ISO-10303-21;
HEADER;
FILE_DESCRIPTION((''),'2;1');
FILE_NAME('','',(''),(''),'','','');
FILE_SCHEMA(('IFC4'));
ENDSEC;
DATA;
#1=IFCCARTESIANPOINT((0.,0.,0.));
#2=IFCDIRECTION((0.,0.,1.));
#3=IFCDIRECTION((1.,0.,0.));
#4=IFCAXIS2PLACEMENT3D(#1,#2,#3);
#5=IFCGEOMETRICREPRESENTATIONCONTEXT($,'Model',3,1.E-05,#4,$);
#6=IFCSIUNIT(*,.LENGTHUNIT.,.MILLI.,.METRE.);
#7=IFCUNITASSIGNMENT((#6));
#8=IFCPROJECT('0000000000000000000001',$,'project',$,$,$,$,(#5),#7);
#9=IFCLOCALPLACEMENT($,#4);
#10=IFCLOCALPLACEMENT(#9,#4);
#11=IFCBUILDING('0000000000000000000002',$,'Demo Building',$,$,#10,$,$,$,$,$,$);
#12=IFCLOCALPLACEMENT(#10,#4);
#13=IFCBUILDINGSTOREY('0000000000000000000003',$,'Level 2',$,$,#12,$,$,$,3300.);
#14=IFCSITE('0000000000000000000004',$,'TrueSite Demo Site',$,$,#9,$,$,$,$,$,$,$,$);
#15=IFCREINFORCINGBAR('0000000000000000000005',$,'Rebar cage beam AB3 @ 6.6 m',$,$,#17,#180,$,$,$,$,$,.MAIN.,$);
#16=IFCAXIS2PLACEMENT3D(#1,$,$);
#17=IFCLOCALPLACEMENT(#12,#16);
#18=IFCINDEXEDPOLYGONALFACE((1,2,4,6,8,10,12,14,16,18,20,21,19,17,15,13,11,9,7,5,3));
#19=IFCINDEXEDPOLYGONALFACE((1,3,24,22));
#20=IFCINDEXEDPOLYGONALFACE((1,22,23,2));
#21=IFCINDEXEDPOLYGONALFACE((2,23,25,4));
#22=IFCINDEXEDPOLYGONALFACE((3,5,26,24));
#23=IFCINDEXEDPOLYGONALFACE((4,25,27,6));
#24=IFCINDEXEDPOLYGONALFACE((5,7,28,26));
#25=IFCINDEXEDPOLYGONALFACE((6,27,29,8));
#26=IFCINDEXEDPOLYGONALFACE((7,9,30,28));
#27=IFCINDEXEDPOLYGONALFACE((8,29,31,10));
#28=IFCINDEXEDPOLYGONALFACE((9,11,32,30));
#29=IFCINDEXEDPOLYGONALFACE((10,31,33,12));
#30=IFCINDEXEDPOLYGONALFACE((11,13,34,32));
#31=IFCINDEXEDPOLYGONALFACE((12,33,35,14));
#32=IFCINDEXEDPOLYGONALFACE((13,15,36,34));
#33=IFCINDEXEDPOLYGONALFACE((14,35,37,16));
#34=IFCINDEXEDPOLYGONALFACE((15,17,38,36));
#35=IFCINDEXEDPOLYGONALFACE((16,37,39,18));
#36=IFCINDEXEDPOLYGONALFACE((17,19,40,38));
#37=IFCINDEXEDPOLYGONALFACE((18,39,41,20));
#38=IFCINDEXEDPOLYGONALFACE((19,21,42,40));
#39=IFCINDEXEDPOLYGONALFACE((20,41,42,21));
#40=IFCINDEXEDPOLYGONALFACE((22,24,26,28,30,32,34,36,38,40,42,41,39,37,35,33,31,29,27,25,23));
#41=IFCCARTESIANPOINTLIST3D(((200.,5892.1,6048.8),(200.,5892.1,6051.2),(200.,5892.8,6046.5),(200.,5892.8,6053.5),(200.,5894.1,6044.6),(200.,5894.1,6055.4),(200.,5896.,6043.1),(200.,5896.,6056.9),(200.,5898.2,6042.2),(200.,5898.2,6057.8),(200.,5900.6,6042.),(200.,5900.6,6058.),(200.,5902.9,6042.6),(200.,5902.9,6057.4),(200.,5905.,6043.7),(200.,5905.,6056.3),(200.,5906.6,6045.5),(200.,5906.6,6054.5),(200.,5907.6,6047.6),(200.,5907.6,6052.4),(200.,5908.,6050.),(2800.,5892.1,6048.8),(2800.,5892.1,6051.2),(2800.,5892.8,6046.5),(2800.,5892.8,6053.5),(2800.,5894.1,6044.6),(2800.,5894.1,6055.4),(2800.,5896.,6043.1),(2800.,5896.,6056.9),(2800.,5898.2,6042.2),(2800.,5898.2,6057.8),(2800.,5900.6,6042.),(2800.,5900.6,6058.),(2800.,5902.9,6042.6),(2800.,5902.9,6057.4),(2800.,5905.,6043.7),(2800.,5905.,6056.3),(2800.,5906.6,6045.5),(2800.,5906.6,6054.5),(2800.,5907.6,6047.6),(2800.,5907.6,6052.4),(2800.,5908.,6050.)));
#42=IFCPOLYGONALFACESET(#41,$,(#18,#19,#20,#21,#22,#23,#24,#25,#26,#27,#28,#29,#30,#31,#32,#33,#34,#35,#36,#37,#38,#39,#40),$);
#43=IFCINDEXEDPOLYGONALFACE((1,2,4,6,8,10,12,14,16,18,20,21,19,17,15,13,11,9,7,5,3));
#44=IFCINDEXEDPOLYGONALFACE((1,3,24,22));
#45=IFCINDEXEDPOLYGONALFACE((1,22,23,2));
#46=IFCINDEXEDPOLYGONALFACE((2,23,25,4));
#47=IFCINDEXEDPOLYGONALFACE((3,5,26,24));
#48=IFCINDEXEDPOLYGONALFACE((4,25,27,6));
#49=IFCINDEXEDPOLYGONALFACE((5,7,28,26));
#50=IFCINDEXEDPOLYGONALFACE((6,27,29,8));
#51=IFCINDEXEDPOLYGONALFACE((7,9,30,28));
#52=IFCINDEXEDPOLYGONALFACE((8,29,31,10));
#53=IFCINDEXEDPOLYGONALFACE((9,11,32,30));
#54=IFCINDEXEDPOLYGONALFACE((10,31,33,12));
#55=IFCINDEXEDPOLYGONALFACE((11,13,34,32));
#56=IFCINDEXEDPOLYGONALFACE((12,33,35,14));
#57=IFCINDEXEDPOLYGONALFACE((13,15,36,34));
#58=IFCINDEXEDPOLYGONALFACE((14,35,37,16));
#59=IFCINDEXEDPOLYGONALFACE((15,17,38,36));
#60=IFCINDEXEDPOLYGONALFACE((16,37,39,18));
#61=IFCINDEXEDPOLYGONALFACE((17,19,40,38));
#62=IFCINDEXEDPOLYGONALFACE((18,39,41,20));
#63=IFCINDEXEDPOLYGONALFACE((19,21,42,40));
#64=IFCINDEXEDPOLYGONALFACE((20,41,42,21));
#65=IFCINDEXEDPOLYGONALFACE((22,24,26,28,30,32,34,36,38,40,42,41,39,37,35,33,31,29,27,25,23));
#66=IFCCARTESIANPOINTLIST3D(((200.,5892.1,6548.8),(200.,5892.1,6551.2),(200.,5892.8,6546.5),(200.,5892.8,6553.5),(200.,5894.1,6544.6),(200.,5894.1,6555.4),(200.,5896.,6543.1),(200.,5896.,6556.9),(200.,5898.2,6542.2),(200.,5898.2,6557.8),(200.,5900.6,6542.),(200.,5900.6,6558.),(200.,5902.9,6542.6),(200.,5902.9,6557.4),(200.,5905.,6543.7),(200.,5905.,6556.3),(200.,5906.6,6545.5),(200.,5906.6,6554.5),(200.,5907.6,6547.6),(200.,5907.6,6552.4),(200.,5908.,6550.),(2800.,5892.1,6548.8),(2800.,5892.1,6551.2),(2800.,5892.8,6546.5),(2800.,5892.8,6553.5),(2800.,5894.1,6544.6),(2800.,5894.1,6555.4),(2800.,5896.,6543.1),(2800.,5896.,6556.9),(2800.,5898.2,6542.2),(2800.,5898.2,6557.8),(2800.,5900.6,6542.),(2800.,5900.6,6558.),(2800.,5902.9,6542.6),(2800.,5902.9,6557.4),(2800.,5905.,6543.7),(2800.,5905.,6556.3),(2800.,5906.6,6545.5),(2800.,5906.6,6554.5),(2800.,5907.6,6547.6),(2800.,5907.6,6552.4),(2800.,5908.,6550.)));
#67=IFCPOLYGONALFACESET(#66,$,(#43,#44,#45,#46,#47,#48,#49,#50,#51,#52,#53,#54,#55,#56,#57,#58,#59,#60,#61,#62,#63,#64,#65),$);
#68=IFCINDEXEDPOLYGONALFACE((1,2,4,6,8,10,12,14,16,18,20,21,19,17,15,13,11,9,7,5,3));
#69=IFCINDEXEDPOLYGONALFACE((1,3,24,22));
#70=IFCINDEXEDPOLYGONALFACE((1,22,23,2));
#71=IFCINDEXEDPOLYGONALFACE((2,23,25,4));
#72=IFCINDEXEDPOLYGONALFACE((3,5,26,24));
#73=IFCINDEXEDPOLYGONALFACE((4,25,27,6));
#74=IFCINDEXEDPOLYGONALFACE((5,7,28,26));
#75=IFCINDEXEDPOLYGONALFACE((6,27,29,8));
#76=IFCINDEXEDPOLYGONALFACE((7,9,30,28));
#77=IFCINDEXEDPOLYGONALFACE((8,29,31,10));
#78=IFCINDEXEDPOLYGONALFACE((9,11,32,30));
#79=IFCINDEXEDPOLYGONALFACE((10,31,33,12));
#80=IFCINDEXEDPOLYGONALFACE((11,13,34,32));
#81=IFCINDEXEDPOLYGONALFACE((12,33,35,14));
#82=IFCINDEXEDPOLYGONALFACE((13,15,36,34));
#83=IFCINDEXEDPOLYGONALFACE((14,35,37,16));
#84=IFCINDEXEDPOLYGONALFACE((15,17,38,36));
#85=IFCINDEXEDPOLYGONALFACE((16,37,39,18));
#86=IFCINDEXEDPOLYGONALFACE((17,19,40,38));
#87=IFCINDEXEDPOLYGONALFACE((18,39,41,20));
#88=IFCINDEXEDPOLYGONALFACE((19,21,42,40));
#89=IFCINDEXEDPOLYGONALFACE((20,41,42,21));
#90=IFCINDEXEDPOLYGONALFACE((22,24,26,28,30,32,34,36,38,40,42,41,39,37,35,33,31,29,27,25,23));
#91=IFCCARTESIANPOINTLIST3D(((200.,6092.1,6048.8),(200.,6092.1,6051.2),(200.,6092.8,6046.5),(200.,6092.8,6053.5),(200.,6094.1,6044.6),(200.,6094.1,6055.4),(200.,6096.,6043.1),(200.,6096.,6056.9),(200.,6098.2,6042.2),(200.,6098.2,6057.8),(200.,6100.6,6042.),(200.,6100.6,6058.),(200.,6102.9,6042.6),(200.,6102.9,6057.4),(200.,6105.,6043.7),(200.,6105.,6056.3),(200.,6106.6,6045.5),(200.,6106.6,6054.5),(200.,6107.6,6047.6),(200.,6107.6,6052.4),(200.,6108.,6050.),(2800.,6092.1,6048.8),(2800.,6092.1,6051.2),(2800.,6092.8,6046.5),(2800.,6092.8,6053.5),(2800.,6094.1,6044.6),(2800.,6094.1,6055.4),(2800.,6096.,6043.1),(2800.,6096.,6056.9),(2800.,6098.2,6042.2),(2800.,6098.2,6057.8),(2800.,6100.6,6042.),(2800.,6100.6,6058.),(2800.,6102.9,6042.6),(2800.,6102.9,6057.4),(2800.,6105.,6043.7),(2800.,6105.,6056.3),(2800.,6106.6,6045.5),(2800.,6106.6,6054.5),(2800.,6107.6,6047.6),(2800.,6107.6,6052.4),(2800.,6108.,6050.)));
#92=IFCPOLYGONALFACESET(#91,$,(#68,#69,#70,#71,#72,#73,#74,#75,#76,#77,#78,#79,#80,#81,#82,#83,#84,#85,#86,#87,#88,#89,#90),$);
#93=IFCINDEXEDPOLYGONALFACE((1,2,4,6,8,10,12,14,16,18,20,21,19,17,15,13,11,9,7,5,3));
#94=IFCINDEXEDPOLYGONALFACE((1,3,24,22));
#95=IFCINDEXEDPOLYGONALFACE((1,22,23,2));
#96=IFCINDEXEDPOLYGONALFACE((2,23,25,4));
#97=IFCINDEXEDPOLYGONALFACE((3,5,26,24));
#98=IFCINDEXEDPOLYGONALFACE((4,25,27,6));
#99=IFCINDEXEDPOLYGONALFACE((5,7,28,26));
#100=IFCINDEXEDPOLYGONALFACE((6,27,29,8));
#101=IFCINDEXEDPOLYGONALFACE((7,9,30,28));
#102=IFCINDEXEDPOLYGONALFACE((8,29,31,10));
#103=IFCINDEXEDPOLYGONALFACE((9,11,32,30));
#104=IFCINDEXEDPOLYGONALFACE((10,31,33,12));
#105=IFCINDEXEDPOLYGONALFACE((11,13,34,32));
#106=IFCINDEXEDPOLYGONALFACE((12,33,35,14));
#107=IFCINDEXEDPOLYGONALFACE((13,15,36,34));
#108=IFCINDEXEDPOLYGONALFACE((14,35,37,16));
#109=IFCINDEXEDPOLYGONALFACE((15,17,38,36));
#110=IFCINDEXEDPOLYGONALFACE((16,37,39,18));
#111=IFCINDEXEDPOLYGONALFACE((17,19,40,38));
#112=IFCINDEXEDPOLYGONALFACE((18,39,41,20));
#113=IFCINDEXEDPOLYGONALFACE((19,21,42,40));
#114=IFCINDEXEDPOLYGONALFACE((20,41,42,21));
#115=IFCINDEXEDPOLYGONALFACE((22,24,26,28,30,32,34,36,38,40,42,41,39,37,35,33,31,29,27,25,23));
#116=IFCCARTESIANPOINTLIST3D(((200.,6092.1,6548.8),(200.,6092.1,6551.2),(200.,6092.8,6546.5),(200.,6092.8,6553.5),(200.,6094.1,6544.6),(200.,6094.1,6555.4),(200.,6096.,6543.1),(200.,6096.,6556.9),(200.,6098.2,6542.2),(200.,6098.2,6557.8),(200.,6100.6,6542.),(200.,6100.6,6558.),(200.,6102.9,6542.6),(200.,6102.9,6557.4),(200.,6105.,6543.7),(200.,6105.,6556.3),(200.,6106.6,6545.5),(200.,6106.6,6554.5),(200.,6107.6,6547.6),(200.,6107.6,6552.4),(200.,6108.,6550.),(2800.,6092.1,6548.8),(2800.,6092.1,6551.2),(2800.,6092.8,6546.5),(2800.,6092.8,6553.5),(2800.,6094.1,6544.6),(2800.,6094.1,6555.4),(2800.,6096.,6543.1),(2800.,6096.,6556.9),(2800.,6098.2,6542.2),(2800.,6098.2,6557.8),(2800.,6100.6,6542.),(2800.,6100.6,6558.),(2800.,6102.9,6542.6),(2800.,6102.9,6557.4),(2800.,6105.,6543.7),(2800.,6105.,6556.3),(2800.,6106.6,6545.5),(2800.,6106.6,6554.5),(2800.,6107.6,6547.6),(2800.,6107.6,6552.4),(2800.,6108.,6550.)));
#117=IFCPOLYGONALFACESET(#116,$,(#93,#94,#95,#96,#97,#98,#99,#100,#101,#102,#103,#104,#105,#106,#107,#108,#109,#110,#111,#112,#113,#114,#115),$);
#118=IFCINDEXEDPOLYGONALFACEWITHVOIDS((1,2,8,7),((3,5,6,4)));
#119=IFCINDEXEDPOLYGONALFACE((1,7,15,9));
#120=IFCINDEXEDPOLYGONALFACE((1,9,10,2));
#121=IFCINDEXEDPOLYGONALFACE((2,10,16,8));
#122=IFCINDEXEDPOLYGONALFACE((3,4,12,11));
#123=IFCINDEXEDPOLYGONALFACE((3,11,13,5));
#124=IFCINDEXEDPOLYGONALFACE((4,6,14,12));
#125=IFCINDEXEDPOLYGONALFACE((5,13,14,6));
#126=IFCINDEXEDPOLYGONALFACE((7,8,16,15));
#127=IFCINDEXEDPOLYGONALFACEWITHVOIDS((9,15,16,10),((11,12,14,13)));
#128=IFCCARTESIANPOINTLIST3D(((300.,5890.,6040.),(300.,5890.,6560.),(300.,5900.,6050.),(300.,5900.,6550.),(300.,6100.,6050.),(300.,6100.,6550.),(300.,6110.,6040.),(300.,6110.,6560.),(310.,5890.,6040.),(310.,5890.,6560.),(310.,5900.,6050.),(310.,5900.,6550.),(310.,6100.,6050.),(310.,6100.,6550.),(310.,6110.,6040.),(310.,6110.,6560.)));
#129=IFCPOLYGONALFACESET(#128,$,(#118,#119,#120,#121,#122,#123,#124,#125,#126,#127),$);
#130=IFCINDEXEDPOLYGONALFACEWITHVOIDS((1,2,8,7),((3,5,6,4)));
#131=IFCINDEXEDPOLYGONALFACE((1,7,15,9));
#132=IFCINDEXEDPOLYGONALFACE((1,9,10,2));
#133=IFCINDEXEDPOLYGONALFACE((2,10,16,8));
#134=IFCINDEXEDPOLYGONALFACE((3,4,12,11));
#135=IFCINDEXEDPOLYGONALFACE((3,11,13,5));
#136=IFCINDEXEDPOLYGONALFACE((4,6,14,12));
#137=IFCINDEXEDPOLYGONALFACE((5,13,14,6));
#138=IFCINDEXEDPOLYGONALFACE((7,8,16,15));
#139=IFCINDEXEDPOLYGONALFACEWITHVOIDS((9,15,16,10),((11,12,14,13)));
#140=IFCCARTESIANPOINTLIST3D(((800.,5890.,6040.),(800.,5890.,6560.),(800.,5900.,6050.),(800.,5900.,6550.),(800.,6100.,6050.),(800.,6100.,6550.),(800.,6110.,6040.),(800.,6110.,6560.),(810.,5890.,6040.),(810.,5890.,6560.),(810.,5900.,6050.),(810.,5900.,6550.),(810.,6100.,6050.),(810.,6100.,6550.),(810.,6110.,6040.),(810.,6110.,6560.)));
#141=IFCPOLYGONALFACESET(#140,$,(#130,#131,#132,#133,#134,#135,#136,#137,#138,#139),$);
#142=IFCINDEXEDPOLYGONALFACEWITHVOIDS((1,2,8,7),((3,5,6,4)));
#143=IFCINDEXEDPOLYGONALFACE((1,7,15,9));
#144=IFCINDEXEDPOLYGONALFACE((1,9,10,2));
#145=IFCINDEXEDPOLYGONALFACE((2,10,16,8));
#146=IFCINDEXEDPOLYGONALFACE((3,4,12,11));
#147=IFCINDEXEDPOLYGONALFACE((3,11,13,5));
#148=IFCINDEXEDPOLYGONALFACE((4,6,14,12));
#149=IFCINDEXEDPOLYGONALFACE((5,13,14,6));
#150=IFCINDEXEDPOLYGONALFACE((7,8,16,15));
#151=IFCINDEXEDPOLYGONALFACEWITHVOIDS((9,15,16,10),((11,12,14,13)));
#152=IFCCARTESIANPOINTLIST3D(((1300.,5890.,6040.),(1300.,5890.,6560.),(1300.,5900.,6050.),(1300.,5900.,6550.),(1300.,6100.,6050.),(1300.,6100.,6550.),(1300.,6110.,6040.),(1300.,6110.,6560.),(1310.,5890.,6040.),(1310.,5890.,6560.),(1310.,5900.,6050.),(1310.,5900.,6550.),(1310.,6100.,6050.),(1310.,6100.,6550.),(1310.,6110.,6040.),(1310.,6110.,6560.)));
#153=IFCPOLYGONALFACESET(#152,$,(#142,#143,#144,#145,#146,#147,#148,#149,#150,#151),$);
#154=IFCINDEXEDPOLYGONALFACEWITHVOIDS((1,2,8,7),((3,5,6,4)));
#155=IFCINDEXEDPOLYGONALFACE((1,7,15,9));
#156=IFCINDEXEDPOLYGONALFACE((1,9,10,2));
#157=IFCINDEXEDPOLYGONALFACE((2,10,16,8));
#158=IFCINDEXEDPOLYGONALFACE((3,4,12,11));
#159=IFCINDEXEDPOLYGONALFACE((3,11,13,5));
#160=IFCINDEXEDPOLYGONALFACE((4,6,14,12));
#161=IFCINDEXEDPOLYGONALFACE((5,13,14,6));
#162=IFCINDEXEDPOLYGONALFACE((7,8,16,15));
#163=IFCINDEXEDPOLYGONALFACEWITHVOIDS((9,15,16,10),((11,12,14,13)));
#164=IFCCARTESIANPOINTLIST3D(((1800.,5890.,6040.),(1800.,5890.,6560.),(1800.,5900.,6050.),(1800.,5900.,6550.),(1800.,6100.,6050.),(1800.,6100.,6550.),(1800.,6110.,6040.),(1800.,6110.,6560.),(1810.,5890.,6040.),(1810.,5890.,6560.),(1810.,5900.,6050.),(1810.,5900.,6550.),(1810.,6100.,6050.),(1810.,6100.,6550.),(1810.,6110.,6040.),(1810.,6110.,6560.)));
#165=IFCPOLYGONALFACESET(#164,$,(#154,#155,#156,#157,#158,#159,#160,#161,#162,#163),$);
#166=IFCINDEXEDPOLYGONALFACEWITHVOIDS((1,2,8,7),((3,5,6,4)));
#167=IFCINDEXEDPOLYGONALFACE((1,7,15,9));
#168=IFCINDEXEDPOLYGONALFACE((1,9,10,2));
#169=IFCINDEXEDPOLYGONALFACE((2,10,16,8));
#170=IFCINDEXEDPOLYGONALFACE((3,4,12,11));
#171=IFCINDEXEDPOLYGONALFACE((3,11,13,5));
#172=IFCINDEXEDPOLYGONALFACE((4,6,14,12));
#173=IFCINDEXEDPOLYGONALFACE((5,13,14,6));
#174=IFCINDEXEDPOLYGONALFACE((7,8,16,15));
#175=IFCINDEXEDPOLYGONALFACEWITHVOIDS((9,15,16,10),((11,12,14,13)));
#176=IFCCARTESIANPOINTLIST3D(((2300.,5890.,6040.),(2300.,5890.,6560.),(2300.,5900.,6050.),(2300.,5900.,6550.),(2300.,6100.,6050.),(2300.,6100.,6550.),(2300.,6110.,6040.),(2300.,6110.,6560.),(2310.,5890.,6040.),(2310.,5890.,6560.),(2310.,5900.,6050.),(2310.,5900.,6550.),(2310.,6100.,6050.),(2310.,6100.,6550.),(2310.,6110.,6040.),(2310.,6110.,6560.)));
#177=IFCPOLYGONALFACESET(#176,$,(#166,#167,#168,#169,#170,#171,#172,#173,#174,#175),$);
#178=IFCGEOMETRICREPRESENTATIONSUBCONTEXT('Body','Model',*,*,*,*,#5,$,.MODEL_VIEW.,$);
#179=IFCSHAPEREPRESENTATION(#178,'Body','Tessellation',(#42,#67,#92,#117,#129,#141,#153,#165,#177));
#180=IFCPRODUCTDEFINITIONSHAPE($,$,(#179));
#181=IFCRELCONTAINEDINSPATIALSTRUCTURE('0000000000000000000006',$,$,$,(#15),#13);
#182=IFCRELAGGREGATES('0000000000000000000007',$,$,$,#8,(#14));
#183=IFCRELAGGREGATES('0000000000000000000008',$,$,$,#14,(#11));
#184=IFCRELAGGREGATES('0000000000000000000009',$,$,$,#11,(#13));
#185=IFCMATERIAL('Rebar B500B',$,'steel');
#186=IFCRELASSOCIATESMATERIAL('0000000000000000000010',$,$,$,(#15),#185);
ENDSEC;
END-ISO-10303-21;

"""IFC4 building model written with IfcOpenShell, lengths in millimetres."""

from ifc_helpers import new_model, si_unit, frame, origin_with_axes, place, context, subcontext, project, spatial, hollow_rectangle, circle, extrude, material, element, save


model = new_model("IFC4")

# Units and contexts
model_context = context("Model", 3, precision=1e-05, world=origin_with_axes())
body_context = subcontext(model_context, "Body", "Model", "MODEL_VIEW")
ifc_project = project(units=[si_unit("LENGTHUNIT", "METRE", prefix="MILLI")], contexts=[model_context])

# Site, building, storey
site_placement = place(None, origin_with_axes())
site = spatial("IfcSite", under=ifc_project, at=site_placement, Name="TrueSite Demo Site")
building_placement = place(site_placement, origin_with_axes())
building = spatial("IfcBuilding", under=site, at=building_placement, Name="Demo Building")
storey_placement = place(building_placement, origin_with_axes())
storey = spatial("IfcBuildingStorey", under=building, at=storey_placement, Name="Level 2", Elevation=3300.0)

# Reinforcing bar
ifc_material_1 = material(Name="Rebar B500B", Category="steel")
for number, where, z_axis, x_axis, name in (
    (1, (200.0, 6000.0, 6300.0), (1.0, 0.0, 0.0), (0.0, 1.0, 0.0), "Rebar cage beam AB3 @ 6.6 m"),
):
    element("IfcReinforcingBar", number, at=place(storey_placement, frame(where, z_axis=z_axis, x_axis=x_axis)), inside=storey, material=ifc_material_1, Name=name, PredefinedType="MAIN", context=body_context, shape_type="SweptSolid", body=[
        extrude(circle(Radius=8.0), frame((-100.0, -250.0, 0.0)), (0.0, 0.0, 1.0), 2600.0),
        extrude(circle(Radius=8.0), frame((-100.0, 250.0, 0.0)), (0.0, 0.0, 1.0), 2600.0),
        extrude(circle(Radius=8.0), frame((100.0, -250.0, 0.0)), (0.0, 0.0, 1.0), 2600.0),
        extrude(circle(Radius=8.0), frame((100.0, 250.0, 0.0)), (0.0, 0.0, 1.0), 2600.0),
        extrude(hollow_rectangle(XDim=220.0, YDim=520.0, WallThickness=10.0), frame((0.0, 0.0, 100.0)), (0.0, 0.0, 1.0), 10.0),
        extrude(hollow_rectangle(XDim=220.0, YDim=520.0, WallThickness=10.0), frame((0.0, 0.0, 600.0)), (0.0, 0.0, 1.0), 10.0),
        extrude(hollow_rectangle(XDim=220.0, YDim=520.0, WallThickness=10.0), frame((0.0, 0.0, 1100.0)), (0.0, 0.0, 1.0), 10.0),
        extrude(hollow_rectangle(XDim=220.0, YDim=520.0, WallThickness=10.0), frame((0.0, 0.0, 1600.0)), (0.0, 0.0, 1.0), 10.0),
        extrude(hollow_rectangle(XDim=220.0, YDim=520.0, WallThickness=10.0), frame((0.0, 0.0, 2100.0)), (0.0, 0.0, 1.0), 10.0),
    ])

save(model, "model.ifc")
